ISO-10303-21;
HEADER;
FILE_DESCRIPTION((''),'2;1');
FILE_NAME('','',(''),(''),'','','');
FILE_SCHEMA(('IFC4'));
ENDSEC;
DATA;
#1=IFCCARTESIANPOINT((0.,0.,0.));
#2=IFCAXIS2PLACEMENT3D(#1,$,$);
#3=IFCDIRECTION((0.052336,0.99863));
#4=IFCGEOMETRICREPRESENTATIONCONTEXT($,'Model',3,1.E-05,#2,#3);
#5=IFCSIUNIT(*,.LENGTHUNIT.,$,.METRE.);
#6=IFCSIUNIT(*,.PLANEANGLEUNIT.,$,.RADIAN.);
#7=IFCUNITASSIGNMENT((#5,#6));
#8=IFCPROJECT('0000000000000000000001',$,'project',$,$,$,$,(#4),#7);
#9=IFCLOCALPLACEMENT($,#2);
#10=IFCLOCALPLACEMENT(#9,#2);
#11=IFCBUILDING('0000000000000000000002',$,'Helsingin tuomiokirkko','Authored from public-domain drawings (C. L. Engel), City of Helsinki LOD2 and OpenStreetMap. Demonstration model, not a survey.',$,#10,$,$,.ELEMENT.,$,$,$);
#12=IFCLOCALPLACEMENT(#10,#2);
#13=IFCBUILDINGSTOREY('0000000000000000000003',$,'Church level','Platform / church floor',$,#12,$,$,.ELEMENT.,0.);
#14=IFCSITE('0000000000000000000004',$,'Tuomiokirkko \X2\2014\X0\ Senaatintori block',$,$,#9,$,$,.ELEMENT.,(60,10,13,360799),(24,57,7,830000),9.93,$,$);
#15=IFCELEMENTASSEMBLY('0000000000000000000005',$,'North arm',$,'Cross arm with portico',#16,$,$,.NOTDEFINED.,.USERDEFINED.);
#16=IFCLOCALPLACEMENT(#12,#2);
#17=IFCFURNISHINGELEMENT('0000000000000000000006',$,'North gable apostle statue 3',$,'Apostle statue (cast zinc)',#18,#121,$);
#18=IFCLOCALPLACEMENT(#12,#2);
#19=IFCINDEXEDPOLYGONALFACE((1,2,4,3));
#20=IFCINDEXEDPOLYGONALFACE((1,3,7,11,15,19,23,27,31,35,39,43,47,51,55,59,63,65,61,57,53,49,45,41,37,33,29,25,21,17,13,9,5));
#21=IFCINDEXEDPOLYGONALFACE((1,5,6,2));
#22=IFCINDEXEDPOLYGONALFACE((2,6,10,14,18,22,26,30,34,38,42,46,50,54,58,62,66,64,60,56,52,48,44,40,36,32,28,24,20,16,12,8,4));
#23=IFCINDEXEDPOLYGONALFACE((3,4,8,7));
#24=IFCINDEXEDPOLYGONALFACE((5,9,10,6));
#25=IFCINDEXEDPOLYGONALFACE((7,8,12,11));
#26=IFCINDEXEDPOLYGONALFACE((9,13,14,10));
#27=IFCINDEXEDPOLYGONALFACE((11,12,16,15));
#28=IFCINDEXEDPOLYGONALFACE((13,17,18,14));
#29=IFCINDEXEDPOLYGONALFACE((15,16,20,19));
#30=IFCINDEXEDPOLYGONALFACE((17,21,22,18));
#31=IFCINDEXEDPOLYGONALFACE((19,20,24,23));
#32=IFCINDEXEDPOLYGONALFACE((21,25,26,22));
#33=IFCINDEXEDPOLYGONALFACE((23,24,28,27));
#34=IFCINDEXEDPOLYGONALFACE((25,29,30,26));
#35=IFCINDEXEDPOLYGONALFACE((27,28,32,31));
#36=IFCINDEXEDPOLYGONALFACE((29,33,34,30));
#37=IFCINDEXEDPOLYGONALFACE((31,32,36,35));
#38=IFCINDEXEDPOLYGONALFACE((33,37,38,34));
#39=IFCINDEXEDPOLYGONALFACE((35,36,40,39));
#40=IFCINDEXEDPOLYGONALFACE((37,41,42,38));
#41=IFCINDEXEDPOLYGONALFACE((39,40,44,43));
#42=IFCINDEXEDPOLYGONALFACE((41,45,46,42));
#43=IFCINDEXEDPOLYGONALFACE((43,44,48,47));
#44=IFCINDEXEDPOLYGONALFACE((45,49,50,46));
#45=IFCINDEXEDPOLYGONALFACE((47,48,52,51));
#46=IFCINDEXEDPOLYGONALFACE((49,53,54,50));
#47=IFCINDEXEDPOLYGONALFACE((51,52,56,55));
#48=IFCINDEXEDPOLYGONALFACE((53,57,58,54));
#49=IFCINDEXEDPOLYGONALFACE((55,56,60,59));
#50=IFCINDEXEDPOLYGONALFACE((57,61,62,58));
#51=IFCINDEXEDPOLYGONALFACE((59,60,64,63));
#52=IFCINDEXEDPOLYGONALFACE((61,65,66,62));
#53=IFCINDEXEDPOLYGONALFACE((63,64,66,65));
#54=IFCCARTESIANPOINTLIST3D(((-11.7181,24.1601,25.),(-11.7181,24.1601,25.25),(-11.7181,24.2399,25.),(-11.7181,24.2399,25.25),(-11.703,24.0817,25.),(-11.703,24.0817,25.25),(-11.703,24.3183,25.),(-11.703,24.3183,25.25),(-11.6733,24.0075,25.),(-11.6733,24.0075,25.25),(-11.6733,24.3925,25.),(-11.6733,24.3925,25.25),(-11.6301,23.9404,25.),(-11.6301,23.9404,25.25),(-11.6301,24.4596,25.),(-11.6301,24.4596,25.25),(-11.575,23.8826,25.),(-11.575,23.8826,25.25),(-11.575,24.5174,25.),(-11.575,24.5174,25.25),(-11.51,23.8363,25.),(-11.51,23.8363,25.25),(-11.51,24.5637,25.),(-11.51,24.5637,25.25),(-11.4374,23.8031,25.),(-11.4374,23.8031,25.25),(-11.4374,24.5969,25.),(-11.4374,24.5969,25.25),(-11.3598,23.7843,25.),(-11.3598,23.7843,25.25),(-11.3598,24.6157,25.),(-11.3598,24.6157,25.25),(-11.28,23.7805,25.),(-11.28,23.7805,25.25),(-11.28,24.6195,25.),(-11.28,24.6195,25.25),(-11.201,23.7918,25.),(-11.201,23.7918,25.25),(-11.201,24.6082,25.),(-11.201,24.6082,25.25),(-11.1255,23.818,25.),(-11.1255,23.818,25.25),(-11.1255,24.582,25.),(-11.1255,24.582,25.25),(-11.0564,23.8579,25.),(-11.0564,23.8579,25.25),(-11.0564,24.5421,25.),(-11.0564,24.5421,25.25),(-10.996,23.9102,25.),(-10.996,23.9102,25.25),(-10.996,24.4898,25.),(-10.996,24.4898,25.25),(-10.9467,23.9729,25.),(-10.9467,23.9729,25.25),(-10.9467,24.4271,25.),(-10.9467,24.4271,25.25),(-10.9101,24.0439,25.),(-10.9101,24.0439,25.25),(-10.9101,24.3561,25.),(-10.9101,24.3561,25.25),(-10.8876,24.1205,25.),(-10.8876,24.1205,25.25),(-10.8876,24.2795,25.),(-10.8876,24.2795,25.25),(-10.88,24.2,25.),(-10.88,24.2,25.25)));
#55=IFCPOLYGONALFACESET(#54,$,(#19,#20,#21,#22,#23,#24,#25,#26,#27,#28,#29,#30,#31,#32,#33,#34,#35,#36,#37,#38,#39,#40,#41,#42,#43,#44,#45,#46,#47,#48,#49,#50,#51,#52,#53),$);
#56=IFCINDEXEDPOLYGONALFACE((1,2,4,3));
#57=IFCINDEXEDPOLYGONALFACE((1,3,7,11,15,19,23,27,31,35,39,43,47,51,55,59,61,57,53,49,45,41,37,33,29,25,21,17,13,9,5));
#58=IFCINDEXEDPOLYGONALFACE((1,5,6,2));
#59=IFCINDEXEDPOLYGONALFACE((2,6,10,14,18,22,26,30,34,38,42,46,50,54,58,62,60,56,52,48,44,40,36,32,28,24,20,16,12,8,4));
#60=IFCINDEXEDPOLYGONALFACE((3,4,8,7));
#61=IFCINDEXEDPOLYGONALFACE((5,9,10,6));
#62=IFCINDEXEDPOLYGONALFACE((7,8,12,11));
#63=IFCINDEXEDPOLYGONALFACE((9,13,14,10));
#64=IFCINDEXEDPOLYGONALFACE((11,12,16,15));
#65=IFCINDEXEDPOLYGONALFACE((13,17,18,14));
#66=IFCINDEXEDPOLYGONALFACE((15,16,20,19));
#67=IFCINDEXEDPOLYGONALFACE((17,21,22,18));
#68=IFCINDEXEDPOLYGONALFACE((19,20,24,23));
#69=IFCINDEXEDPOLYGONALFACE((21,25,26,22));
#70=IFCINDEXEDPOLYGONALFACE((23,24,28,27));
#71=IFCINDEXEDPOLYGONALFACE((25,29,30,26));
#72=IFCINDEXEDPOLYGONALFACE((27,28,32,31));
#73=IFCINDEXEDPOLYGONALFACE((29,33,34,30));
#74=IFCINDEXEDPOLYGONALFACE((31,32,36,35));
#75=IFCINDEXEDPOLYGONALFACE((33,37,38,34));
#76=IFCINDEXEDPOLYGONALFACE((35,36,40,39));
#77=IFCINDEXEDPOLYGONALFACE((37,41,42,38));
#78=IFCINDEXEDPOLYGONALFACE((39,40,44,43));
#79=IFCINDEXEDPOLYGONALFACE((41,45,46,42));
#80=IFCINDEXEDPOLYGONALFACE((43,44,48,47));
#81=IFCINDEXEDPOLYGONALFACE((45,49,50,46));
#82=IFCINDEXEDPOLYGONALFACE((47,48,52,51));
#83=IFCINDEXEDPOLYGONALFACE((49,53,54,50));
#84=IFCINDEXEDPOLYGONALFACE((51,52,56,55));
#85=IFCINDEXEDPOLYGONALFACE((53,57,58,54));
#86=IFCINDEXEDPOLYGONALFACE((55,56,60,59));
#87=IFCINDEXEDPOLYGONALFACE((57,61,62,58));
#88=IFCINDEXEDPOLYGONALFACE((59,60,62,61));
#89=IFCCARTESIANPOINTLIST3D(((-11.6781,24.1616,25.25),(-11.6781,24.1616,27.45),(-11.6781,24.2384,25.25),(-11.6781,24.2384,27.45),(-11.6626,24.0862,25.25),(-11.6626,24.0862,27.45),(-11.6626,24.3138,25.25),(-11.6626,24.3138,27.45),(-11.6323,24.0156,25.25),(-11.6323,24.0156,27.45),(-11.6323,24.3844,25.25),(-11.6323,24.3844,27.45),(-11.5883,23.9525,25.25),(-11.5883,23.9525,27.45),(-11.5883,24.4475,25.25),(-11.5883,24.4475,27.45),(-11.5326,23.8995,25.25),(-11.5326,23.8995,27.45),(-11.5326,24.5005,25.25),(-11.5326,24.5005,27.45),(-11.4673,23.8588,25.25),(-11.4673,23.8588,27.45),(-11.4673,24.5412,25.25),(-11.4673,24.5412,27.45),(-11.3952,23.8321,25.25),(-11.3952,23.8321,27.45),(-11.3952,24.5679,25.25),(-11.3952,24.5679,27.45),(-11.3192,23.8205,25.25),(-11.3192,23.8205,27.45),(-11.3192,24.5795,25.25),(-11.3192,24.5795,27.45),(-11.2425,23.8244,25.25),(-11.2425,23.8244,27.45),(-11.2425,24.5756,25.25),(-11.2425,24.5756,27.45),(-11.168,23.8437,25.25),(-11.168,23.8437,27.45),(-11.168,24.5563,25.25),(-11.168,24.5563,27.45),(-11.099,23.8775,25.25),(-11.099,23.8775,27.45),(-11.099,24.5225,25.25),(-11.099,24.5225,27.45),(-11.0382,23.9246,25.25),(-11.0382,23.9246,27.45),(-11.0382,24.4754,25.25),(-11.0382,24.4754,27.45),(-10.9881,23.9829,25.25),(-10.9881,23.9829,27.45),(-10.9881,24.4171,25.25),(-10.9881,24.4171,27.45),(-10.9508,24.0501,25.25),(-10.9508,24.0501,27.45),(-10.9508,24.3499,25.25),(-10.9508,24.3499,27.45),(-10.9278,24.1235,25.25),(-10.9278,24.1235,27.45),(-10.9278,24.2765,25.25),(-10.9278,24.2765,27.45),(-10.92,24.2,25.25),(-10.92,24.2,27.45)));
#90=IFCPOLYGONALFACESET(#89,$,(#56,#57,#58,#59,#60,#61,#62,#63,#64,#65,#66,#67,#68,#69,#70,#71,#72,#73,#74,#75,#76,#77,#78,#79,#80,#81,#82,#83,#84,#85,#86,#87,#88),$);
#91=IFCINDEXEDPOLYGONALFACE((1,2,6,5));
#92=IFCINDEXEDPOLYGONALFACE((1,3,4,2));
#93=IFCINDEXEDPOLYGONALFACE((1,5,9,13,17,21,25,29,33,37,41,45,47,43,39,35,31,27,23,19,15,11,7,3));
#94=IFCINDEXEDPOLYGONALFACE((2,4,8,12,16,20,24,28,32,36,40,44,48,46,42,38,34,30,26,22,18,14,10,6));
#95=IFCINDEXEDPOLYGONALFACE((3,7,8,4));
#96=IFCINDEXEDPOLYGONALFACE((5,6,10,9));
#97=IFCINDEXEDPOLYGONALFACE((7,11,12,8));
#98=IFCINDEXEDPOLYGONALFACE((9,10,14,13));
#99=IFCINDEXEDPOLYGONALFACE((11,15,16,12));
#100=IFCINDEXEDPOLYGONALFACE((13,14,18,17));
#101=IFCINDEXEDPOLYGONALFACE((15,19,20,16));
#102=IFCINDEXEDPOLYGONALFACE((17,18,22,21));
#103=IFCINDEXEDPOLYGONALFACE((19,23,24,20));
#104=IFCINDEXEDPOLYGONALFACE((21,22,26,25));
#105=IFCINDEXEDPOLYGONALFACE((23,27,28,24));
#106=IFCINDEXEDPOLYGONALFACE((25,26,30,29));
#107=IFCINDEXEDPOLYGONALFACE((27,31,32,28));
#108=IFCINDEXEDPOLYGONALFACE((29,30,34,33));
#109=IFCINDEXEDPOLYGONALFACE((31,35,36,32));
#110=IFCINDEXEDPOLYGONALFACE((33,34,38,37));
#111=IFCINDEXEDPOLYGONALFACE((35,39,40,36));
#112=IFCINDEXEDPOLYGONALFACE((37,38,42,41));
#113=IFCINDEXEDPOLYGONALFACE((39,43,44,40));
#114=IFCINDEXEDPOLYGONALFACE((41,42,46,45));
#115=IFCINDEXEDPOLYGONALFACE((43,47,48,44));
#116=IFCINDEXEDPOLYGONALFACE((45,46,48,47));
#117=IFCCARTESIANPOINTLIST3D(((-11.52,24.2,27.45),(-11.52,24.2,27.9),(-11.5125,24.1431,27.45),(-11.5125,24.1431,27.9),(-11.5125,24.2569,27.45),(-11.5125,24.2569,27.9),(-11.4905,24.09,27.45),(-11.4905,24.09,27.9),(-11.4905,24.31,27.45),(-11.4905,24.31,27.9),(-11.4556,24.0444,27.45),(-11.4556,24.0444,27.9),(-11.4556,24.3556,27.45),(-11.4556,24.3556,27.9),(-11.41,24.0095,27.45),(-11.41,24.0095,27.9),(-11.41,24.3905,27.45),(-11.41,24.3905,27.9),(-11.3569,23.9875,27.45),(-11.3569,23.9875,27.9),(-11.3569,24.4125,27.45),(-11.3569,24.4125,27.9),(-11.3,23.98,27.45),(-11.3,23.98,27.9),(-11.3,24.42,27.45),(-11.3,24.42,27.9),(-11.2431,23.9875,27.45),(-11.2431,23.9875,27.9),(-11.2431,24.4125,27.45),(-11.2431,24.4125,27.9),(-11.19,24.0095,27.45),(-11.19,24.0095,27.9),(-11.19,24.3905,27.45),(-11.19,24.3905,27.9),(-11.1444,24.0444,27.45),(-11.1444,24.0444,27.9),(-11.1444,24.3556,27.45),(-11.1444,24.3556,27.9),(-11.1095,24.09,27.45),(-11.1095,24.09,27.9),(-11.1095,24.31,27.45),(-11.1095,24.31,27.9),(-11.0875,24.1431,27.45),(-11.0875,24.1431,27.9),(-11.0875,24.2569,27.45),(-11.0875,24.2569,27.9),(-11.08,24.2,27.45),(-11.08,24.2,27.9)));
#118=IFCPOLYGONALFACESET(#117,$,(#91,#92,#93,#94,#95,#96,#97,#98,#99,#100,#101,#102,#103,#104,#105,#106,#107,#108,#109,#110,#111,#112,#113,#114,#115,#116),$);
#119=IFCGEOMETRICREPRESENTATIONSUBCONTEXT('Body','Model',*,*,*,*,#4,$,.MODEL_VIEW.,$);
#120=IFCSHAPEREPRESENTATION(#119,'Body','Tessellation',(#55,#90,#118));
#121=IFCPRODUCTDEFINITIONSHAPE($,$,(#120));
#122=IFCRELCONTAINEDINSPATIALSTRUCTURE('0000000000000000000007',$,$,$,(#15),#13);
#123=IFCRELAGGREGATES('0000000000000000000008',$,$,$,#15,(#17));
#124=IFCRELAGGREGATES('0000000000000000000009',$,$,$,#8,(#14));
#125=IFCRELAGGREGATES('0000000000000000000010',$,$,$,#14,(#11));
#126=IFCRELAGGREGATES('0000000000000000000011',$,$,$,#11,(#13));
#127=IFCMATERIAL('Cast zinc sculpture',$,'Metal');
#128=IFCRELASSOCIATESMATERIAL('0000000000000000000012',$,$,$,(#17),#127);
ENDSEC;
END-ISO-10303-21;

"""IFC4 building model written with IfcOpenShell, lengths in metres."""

from ifc_helpers import new_model, si_unit, direction, frame, origin, origin_2d_with_axis, place, context, subcontext, project, spatial, circle, extrude, material, element, aggregate, save


model = new_model("IFC4")

# Units and contexts
model_context = context("Model", 3, precision=1e-05, world=origin(), true_north=direction((0.052336, 0.99863)))
body_context = subcontext(model_context, "Body", "Model", "MODEL_VIEW")
ifc_project = project(units=[si_unit("LENGTHUNIT", "METRE"), si_unit("PLANEANGLEUNIT", "RADIAN")], contexts=[model_context])

# Site, building, storey
site_placement = place(None, origin())
site = spatial("IfcSite", under=ifc_project, at=site_placement, Name="Tuomiokirkko — Senaatintori block", CompositionType="ELEMENT", RefLatitude=(60, 10, 13, 360799), RefLongitude=(24, 57, 7, 830000), RefElevation=9.93)
building_placement = place(site_placement, origin())
building = spatial("IfcBuilding", under=site, at=building_placement, Name="Helsingin tuomiokirkko", Description="Authored from public-domain drawings (C. L. Engel), City of Helsinki LOD2 and OpenStreetMap. Demonstration model, not a survey.", CompositionType="ELEMENT")
storey_placement = place(building_placement, origin())
storey = spatial("IfcBuildingStorey", under=building, at=storey_placement, Name="Church level", Description="Platform / church floor", CompositionType="ELEMENT", Elevation=0.0)

# Element assembly
assembly_1_placement = place(building_placement, origin())
assembly_1 = element("IfcElementAssembly", 1, at=assembly_1_placement, inside=storey, Name="North arm", ObjectType="Cross arm with portico", AssemblyPlace="NOTDEFINED", PredefinedType="USERDEFINED")

# Furnishing element
ifc_material_1 = material(Name="Cast zinc sculpture", Category="Metal")
furnishing_1_placement = place(building_placement, origin())
furnishing_1 = element("IfcFurnishingElement", 2, at=furnishing_1_placement, material=ifc_material_1, Name="North gable apostle statue 3", ObjectType="Apostle statue (cast zinc)", context=body_context, shape_type="SweptSolid", body=[
    extrude(circle(Radius=0.42, at=origin_2d_with_axis()), frame((-11.3, 24.2, 25.0)), (0.0, 0.0, 1.0), 0.25),
    extrude(circle(Radius=0.38, at=origin_2d_with_axis()), frame((-11.3, 24.2, 25.25)), (0.0, 0.0, 1.0), 2.2),
    extrude(circle(Radius=0.22, at=origin_2d_with_axis()), frame((-11.3, 24.2, 27.45)), (0.0, 0.0, 1.0), 0.45),
])
aggregate(assembly_1, [furnishing_1])

save(model, "model.ifc")
